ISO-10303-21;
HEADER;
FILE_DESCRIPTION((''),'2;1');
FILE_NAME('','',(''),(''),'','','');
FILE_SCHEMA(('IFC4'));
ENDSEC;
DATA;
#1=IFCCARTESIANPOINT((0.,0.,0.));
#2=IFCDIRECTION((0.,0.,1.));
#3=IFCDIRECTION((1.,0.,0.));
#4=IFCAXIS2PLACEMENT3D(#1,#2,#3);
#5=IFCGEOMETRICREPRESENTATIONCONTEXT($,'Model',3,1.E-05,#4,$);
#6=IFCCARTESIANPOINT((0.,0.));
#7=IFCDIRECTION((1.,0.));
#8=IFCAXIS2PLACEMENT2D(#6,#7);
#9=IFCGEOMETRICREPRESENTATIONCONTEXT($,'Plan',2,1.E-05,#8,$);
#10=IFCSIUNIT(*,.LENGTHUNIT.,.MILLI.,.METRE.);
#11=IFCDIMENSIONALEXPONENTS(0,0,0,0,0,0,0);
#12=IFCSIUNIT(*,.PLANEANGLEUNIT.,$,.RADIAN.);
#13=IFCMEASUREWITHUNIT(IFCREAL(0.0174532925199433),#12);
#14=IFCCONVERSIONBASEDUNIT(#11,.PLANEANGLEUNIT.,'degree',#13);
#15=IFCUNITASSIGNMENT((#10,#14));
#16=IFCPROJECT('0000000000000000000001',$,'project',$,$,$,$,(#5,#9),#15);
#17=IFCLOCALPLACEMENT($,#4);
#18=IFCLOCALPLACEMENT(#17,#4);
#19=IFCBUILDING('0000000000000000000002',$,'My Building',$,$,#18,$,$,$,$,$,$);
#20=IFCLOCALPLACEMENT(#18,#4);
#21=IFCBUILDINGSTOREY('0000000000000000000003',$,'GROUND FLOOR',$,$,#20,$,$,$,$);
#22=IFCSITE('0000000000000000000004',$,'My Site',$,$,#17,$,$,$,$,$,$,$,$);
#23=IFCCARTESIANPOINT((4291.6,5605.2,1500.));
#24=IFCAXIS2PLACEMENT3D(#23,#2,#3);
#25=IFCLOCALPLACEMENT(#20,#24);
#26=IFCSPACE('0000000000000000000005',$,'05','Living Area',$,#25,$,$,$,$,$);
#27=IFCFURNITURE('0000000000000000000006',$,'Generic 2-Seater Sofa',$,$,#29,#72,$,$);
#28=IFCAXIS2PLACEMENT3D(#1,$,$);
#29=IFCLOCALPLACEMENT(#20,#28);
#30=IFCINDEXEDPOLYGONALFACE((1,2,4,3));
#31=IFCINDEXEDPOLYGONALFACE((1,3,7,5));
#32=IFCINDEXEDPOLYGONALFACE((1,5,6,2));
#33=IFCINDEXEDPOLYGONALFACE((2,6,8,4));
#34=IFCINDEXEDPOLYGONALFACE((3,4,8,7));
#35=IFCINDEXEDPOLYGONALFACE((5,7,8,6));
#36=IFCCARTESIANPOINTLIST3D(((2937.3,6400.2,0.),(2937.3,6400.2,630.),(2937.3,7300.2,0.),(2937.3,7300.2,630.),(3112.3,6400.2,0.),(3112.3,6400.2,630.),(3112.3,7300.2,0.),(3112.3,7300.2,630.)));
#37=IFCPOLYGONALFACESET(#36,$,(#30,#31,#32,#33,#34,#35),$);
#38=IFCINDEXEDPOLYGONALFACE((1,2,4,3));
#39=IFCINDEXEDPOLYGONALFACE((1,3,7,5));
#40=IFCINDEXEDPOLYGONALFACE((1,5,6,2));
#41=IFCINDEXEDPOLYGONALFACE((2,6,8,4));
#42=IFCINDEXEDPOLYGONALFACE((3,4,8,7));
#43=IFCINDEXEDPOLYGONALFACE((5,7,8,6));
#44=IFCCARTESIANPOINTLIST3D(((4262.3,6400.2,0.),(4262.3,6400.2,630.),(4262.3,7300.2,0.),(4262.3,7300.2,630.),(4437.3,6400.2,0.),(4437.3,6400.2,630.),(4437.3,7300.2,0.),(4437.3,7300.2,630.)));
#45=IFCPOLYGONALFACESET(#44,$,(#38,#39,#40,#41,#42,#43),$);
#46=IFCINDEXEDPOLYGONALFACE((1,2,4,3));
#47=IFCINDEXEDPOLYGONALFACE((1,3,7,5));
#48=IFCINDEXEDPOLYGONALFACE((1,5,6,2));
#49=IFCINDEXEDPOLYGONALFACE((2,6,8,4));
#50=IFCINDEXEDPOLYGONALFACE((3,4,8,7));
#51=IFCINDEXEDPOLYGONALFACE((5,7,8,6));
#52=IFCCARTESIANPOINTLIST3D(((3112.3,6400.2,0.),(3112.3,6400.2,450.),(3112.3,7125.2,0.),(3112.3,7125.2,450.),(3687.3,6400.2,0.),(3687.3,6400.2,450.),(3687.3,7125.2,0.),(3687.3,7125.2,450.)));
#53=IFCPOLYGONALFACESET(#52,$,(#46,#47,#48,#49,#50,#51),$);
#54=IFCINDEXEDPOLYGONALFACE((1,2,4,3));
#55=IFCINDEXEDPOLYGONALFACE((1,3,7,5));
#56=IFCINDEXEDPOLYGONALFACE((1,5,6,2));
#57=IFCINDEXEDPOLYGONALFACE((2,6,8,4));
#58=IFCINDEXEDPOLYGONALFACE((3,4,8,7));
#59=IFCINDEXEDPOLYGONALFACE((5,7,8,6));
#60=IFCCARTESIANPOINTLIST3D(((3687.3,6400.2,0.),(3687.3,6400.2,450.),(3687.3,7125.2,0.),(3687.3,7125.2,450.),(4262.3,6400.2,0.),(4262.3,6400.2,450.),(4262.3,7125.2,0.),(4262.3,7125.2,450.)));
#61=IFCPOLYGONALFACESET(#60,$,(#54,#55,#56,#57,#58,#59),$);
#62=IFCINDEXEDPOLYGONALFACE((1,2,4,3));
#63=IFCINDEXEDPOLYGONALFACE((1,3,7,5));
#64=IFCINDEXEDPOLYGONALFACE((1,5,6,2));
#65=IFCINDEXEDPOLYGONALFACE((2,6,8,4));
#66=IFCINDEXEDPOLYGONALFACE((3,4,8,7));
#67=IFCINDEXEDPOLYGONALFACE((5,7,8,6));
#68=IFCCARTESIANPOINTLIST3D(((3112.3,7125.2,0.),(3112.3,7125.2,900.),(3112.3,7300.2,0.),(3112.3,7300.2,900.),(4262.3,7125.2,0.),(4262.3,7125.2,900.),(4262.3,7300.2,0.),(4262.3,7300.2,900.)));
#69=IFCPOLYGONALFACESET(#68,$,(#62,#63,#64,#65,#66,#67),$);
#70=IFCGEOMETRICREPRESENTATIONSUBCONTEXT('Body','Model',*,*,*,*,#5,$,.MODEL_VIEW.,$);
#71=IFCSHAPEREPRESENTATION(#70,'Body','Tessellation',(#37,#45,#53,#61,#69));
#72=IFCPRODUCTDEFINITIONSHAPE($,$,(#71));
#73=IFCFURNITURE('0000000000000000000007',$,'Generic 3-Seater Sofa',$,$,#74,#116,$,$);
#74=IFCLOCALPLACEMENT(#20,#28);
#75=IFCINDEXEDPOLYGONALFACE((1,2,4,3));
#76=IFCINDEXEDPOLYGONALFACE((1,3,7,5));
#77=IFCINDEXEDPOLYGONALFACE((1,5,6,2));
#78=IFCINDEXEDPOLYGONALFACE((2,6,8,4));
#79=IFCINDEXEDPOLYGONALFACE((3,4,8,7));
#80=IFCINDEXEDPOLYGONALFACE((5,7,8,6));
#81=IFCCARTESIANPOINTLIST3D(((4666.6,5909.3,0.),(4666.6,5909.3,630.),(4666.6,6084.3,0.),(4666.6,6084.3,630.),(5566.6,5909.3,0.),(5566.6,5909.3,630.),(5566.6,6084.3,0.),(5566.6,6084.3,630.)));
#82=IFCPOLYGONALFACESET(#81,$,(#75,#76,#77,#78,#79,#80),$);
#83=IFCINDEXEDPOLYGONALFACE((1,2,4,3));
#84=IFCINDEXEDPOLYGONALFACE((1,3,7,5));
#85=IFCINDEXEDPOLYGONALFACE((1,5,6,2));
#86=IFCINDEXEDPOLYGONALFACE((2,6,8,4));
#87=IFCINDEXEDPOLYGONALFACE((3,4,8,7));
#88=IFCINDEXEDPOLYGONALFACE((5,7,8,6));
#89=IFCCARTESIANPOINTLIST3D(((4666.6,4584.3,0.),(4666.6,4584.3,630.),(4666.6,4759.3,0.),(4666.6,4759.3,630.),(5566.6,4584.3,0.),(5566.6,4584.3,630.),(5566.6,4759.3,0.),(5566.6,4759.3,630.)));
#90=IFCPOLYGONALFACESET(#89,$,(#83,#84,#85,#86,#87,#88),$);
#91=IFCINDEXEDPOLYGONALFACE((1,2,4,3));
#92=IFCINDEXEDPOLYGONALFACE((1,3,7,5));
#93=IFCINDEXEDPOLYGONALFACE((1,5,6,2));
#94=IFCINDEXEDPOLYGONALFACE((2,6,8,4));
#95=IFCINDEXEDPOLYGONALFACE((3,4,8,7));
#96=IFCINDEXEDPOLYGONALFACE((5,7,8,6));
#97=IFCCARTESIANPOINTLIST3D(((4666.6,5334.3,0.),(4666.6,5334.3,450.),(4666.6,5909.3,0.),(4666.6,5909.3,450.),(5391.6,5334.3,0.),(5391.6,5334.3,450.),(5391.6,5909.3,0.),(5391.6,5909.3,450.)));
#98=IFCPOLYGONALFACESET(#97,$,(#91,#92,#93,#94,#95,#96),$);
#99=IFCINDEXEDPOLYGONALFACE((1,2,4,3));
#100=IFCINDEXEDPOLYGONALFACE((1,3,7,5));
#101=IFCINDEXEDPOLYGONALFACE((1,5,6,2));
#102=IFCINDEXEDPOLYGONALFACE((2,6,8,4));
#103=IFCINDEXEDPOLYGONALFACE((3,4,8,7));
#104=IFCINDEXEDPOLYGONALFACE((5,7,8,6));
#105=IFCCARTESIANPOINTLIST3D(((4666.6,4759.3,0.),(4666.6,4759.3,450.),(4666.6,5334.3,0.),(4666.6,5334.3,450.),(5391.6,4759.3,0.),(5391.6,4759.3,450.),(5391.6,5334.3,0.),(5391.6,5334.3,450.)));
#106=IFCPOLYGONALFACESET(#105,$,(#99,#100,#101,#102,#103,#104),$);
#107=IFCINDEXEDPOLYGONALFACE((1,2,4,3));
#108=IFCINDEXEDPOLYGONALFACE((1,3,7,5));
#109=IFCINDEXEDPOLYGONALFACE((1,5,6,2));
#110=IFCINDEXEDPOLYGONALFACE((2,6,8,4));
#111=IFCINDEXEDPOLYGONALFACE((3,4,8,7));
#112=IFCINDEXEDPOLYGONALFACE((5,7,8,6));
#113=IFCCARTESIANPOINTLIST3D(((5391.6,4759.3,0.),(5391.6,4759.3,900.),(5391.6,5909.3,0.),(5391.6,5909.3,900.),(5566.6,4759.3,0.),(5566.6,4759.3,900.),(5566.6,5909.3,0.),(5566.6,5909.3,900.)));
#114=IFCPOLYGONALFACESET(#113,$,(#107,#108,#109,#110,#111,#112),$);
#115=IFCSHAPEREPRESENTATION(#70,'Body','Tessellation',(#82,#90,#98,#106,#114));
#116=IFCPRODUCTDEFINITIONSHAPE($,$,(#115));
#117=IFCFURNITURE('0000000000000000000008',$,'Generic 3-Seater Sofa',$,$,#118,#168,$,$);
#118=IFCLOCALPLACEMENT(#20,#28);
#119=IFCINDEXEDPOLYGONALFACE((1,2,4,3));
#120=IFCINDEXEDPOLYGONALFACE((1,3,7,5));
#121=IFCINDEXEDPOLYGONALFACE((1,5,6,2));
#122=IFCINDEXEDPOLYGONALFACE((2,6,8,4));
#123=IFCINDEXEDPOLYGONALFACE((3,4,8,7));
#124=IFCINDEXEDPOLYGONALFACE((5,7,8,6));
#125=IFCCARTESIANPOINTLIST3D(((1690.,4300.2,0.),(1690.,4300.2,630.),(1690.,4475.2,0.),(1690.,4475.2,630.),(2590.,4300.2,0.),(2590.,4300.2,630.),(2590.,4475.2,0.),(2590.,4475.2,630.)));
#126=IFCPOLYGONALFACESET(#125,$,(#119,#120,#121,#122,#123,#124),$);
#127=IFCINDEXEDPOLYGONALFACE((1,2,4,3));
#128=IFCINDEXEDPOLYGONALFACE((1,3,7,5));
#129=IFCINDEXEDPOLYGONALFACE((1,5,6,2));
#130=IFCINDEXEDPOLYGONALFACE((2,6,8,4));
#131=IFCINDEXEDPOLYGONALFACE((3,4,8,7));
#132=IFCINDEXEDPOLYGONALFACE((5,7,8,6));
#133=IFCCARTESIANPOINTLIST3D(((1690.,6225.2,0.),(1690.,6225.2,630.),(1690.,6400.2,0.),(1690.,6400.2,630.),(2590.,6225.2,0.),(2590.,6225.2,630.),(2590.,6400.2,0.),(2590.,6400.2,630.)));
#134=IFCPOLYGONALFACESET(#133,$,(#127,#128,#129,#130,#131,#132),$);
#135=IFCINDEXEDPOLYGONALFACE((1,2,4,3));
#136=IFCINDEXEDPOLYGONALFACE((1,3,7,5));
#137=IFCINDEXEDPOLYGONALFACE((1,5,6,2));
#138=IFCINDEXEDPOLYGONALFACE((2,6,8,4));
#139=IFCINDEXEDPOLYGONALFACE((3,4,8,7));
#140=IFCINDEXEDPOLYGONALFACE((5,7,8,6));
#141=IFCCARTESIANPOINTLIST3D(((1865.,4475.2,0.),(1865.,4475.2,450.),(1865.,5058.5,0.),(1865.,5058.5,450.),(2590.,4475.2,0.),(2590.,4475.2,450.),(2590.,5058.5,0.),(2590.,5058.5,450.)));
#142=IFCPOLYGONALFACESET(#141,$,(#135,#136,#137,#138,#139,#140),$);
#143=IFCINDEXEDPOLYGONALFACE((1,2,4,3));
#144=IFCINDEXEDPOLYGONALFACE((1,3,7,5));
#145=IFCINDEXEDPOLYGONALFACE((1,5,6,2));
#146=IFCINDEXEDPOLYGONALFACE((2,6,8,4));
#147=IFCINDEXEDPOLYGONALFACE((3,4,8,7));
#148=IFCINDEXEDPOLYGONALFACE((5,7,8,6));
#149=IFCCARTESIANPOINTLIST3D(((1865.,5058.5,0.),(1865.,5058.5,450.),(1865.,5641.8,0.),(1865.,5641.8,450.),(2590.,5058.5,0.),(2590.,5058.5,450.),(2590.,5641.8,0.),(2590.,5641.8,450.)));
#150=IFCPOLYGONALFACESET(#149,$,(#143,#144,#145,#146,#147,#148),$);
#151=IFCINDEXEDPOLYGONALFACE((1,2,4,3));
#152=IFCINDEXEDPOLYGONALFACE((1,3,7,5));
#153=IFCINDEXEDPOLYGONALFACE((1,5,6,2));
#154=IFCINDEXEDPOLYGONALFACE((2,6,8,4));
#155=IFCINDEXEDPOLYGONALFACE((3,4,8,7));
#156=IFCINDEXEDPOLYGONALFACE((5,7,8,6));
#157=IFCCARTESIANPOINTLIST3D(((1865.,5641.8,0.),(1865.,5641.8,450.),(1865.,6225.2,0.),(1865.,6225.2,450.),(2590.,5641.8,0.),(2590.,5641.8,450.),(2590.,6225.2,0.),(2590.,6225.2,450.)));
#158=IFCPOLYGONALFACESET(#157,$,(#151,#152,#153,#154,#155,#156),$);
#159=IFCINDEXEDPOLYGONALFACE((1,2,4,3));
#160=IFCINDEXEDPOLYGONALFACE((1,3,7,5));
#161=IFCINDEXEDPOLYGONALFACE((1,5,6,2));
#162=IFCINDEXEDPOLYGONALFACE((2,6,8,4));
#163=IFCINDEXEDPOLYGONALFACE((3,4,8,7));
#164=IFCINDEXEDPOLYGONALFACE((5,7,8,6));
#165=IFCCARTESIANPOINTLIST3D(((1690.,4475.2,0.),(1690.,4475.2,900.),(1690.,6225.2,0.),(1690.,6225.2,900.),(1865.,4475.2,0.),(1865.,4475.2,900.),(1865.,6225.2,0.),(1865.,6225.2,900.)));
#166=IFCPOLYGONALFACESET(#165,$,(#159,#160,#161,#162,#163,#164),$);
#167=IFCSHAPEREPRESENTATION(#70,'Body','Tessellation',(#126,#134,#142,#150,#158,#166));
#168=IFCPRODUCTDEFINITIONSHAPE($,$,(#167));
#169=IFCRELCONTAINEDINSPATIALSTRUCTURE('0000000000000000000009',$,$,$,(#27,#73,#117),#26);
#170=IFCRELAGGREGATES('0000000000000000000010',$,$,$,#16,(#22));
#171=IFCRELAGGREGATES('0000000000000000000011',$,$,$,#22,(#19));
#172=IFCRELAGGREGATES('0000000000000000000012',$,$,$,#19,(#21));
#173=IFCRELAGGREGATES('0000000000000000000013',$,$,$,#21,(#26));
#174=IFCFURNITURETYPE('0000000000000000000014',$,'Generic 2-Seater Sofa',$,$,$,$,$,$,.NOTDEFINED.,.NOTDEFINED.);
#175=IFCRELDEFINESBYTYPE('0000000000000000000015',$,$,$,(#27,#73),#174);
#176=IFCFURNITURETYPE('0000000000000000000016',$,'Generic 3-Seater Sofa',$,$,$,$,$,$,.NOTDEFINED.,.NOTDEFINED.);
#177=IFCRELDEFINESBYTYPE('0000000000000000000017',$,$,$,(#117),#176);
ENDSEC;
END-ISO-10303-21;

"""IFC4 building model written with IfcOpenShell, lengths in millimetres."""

from ifc_helpers import new_model, entity, si_unit, converted_unit, frame, origin_with_axes, origin_2d_with_axis, place, context, subcontext, project, spatial, line, indexed_curve, outline, extrude, shape, source, transform, mapped, type_object, type_shapes, element, save


model = new_model("IFC4")

# Units and contexts
model_context = context("Model", 3, precision=1e-05, world=origin_with_axes())
plan_context = context("Plan", 2, precision=1e-05, world=origin_2d_with_axis())
body_context_1 = subcontext(model_context, "Body", "Model", "MODEL_VIEW")
body_context_2 = subcontext(plan_context, "Body", "Plan", "PLAN_VIEW")
ifc_project = project(units=[si_unit("LENGTHUNIT", "METRE", prefix="MILLI"), converted_unit("PLANEANGLEUNIT", "degree", entity("IfcReal", 0.0174532925199433), si_unit("PLANEANGLEUNIT", "RADIAN"), dimensions=[0, 0, 0, 0, 0, 0, 0])], contexts=[model_context, plan_context])

# Site, building, storey
site_placement = place(None, origin_with_axes())
site = spatial("IfcSite", under=ifc_project, at=site_placement, Name="My Site")
building_placement = place(site_placement, origin_with_axes())
building = spatial("IfcBuilding", under=site, at=building_placement, Name="My Building")
storey_placement = place(building_placement, origin_with_axes())
storey = spatial("IfcBuildingStorey", under=building, at=storey_placement, Name="GROUND FLOOR")

# Shared definitions
space_1_placement = place(storey_placement, frame((4291.6, 5605.2, 1500.0), z_axis=(0.0, 0.0, 1.0), x_axis=(1.0, 0.0, 0.0)))
space_1 = spatial("IfcSpace", under=storey, at=space_1_placement, Name="05", Description="Living Area")

# Furniture
furniture_type_1 = type_object("IfcFurnitureType", Name="Generic 2-Seater Sofa", AssemblyPlace="NOTDEFINED", PredefinedType="NOTDEFINED")
shared_shape_1 = source(origin_with_axes(), body_context_1, "Body", "SweptSolid", [
    extrude(outline(indexed_curve([(0.0, 0.0), (175.0, 0.0), (175.0, 900.0), (0.0, 900.0)], segments=[line(1, 2, 3, 4, 1)])), frame((-750.0, -900.0, 0.0), z_axis=(0.0, 0.0, 1.0), x_axis=(1.0, 0.0, 0.0)), (0.0, 0.0, 1.0), 630.0),
    extrude(outline(indexed_curve([(0.0, 0.0), (175.0, 0.0), (175.0, 900.0), (0.0, 900.0)], segments=[line(1, 2, 3, 4, 1)])), frame((575.0, -900.0, 0.0), z_axis=(0.0, 0.0, 1.0), x_axis=(1.0, 0.0, 0.0)), (0.0, 0.0, 1.0), 630.0),
    extrude(outline(indexed_curve([(175.0, 0.0), (750.0, 0.0), (750.0, 725.0), (175.0, 725.0)], segments=[line(1, 2, 3, 4, 1)])), frame((-750.0, -900.0, 0.0), z_axis=(0.0, 0.0, 1.0), x_axis=(1.0, 0.0, 0.0)), (0.0, 0.0, 1.0), 450.0),
    extrude(outline(indexed_curve([(750.0, 0.0), (1325.0, 0.0), (1325.0, 725.0), (750.0, 725.0)], segments=[line(1, 2, 3, 4, 1)])), frame((-750.0, -900.0, 0.0), z_axis=(0.0, 0.0, 1.0), x_axis=(1.0, 0.0, 0.0)), (0.0, 0.0, 1.0), 450.0),
    extrude(outline(indexed_curve([(175.0, 725.0), (1325.0, 725.0), (1325.0, 900.0), (175.0, 900.0)], segments=[line(1, 2, 3, 4, 1)])), frame((-750.0, -900.0, 0.0), z_axis=(0.0, 0.0, 1.0), x_axis=(1.0, 0.0, 0.0)), (0.0, 0.0, 1.0), 900.0),
])
shared_shape_2 = source(origin_with_axes(), body_context_2, "Body", "Curve2D", [
    entity("IfcIndexedPolyCurve", entity("IfcCartesianPointList2D", [[-750.0, -900.0], [-575.0, -900.0], [-575.0, 0.0], [-750.0, 0.0]]), [entity("IfcLineIndex", [1, 2, 3, 4, 1])]),
    entity("IfcIndexedPolyCurve", entity("IfcCartesianPointList2D", [[575.0, -900.0], [750.0, -900.0], [750.0, 0.0], [575.0, 0.0]]), [entity("IfcLineIndex", [1, 2, 3, 4, 1])]),
    entity("IfcIndexedPolyCurve", entity("IfcCartesianPointList2D", [[-575.0, -900.0], [0.0, -900.0], [0.0, -175.0], [-575.0, -175.0]]), [entity("IfcLineIndex", [1, 2, 3, 4, 1])]),
    entity("IfcIndexedPolyCurve", entity("IfcCartesianPointList2D", [[0.0, -900.0], [575.0, -900.0], [575.0, -175.0], [0.0, -175.0]]), [entity("IfcLineIndex", [1, 2, 3, 4, 1])]),
    entity("IfcIndexedPolyCurve", entity("IfcCartesianPointList2D", [[-575.0, -175.0], [575.0, -175.0], [575.0, 0.0], [-575.0, 0.0]]), [entity("IfcLineIndex", [1, 2, 3, 4, 1])]),
])
type_shapes(furniture_type_1, [shared_shape_1, shared_shape_2])
for number, where, z_axis, x_axis, name in (
    (1, (-604.4, 1695.0, -1500.0), (0.0, 0.0, 1.0), (1.0, 0.0, 0.0), "Generic 2-Seater Sofa"),
    (2, (1274.9, -270.9, -1500.0), (0.0, 0.0, 1.0), (0.0, -1.0, 0.0), "Generic 3-Seater Sofa"),
):
    element("IfcFurniture", number, at=place(space_1_placement, frame(where, z_axis=z_axis, x_axis=x_axis)), inside=space_1, type_object=furniture_type_1, Name=name, shapes=[
        shape(body_context_1, "Body", "MappedRepresentation", [mapped(shared_shape_1, transform((0.0, 0.0, 0.0), x_axis=(1.0, 0.0, 0.0), y_axis=(0.0, 1.0, 0.0), z_axis=(0.0, 0.0, 1.0), scale=1.0))]),
        shape(body_context_2, "Body", "MappedRepresentation", [mapped(shared_shape_2, transform((0.0, 0.0, 0.0), x_axis=(1.0, 0.0, 0.0), y_axis=(0.0, 1.0, 0.0), z_axis=(0.0, 0.0, 1.0), scale=1.0))]),
    ])
furniture_type_2 = type_object("IfcFurnitureType", Name="Generic 3-Seater Sofa", AssemblyPlace="NOTDEFINED", PredefinedType="NOTDEFINED")
shared_shape_3 = source(origin_with_axes(), body_context_1, "Body", "SweptSolid", [
    extrude(outline(indexed_curve([(0.0, 0.0), (175.0, 0.0), (175.0, 900.0), (0.0, 900.0)], segments=[line(1, 2, 3, 4, 1)])), frame((-1050.0, -900.0, 0.0), z_axis=(0.0, 0.0, 1.0), x_axis=(1.0, 0.0, 0.0)), (0.0, 0.0, 1.0), 630.0),
    extrude(outline(indexed_curve([(0.0, 0.0), (175.0, 0.0), (175.0, 900.0), (0.0, 900.0)], segments=[line(1, 2, 3, 4, 1)])), frame((875.0, -900.0, 0.0), z_axis=(0.0, 0.0, 1.0), x_axis=(1.0, 0.0, 0.0)), (0.0, 0.0, 1.0), 630.0),
    extrude(outline(indexed_curve([(175.0, 0.0), (758.3, 0.0), (758.3, 725.0), (175.0, 725.0)], segments=[line(1, 2, 3, 4, 1)])), frame((-1050.0, -900.0, 0.0), z_axis=(0.0, 0.0, 1.0), x_axis=(1.0, 0.0, 0.0)), (0.0, 0.0, 1.0), 450.0),
    extrude(outline(indexed_curve([(758.3, 0.0), (1341.7, 0.0), (1341.7, 725.0), (758.3, 725.0)], segments=[line(1, 2, 3, 4, 1)])), frame((-1050.0, -900.0, 0.0), z_axis=(0.0, 0.0, 1.0), x_axis=(1.0, 0.0, 0.0)), (0.0, 0.0, 1.0), 450.0),
    extrude(outline(indexed_curve([(1341.7, 0.0), (1925.0, 0.0), (1925.0, 725.0), (1341.7, 725.0)], segments=[line(1, 2, 3, 4, 1)])), frame((-1050.0, -900.0, 0.0), z_axis=(0.0, 0.0, 1.0), x_axis=(1.0, 0.0, 0.0)), (0.0, 0.0, 1.0), 450.0),
    extrude(outline(indexed_curve([(175.0, 725.0), (1925.0, 725.0), (1925.0, 900.0), (175.0, 900.0)], segments=[line(1, 2, 3, 4, 1)])), frame((-1050.0, -900.0, 0.0), z_axis=(0.0, 0.0, 1.0), x_axis=(1.0, 0.0, 0.0)), (0.0, 0.0, 1.0), 900.0),
])
shared_shape_4 = source(origin_with_axes(), body_context_2, "Body", "Curve2D", [
    entity("IfcIndexedPolyCurve", entity("IfcCartesianPointList2D", [[-1050.0, -900.0], [-875.0, -900.0], [-875.0, 0.0], [-1050.0, 0.0]]), [entity("IfcLineIndex", [1, 2, 3, 4, 1])]),
    entity("IfcIndexedPolyCurve", entity("IfcCartesianPointList2D", [[875.0, -900.0], [1050.0, -900.0], [1050.0, 0.0], [875.0, 0.0]]), [entity("IfcLineIndex", [1, 2, 3, 4, 1])]),
    entity("IfcIndexedPolyCurve", entity("IfcCartesianPointList2D", [[-875.0, -900.0], [-291.7, -900.0], [-291.7, -175.0], [-875.0, -175.0]]), [entity("IfcLineIndex", [1, 2, 3, 4, 1])]),
    entity("IfcIndexedPolyCurve", entity("IfcCartesianPointList2D", [[-291.7, -900.0], [291.7, -900.0], [291.7, -175.0], [-291.7, -175.0]]), [entity("IfcLineIndex", [1, 2, 3, 4, 1])]),
    entity("IfcIndexedPolyCurve", entity("IfcCartesianPointList2D", [[291.7, -900.0], [875.0, -900.0], [875.0, -175.0], [291.7, -175.0]]), [entity("IfcLineIndex", [1, 2, 3, 4, 1])]),
    entity("IfcIndexedPolyCurve", entity("IfcCartesianPointList2D", [[-875.0, -175.0], [875.0, -175.0], [875.0, 0.0], [-875.0, 0.0]]), [entity("IfcLineIndex", [1, 2, 3, 4, 1])]),
])
type_shapes(furniture_type_2, [shared_shape_3, shared_shape_4])
furniture_1_placement = place(space_1_placement, frame((-2601.6, -255.0, -1500.0), z_axis=(0.0, 0.0, 1.0), x_axis=(0.0, 1.0, 0.0)))
element("IfcFurniture", 3, at=furniture_1_placement, inside=space_1, type_object=furniture_type_2, Name="Generic 3-Seater Sofa", shapes=[
    shape(body_context_1, "Body", "MappedRepresentation", [mapped(shared_shape_3, transform((0.0, 0.0, 0.0), x_axis=(1.0, 0.0, 0.0), y_axis=(0.0, 1.0, 0.0), z_axis=(0.0, 0.0, 1.0), scale=1.0))]),
    shape(body_context_2, "Body", "MappedRepresentation", [mapped(shared_shape_4, transform((0.0, 0.0, 0.0), x_axis=(1.0, 0.0, 0.0), y_axis=(0.0, 1.0, 0.0), z_axis=(0.0, 0.0, 1.0), scale=1.0))]),
])

save(model, "model.ifc")
